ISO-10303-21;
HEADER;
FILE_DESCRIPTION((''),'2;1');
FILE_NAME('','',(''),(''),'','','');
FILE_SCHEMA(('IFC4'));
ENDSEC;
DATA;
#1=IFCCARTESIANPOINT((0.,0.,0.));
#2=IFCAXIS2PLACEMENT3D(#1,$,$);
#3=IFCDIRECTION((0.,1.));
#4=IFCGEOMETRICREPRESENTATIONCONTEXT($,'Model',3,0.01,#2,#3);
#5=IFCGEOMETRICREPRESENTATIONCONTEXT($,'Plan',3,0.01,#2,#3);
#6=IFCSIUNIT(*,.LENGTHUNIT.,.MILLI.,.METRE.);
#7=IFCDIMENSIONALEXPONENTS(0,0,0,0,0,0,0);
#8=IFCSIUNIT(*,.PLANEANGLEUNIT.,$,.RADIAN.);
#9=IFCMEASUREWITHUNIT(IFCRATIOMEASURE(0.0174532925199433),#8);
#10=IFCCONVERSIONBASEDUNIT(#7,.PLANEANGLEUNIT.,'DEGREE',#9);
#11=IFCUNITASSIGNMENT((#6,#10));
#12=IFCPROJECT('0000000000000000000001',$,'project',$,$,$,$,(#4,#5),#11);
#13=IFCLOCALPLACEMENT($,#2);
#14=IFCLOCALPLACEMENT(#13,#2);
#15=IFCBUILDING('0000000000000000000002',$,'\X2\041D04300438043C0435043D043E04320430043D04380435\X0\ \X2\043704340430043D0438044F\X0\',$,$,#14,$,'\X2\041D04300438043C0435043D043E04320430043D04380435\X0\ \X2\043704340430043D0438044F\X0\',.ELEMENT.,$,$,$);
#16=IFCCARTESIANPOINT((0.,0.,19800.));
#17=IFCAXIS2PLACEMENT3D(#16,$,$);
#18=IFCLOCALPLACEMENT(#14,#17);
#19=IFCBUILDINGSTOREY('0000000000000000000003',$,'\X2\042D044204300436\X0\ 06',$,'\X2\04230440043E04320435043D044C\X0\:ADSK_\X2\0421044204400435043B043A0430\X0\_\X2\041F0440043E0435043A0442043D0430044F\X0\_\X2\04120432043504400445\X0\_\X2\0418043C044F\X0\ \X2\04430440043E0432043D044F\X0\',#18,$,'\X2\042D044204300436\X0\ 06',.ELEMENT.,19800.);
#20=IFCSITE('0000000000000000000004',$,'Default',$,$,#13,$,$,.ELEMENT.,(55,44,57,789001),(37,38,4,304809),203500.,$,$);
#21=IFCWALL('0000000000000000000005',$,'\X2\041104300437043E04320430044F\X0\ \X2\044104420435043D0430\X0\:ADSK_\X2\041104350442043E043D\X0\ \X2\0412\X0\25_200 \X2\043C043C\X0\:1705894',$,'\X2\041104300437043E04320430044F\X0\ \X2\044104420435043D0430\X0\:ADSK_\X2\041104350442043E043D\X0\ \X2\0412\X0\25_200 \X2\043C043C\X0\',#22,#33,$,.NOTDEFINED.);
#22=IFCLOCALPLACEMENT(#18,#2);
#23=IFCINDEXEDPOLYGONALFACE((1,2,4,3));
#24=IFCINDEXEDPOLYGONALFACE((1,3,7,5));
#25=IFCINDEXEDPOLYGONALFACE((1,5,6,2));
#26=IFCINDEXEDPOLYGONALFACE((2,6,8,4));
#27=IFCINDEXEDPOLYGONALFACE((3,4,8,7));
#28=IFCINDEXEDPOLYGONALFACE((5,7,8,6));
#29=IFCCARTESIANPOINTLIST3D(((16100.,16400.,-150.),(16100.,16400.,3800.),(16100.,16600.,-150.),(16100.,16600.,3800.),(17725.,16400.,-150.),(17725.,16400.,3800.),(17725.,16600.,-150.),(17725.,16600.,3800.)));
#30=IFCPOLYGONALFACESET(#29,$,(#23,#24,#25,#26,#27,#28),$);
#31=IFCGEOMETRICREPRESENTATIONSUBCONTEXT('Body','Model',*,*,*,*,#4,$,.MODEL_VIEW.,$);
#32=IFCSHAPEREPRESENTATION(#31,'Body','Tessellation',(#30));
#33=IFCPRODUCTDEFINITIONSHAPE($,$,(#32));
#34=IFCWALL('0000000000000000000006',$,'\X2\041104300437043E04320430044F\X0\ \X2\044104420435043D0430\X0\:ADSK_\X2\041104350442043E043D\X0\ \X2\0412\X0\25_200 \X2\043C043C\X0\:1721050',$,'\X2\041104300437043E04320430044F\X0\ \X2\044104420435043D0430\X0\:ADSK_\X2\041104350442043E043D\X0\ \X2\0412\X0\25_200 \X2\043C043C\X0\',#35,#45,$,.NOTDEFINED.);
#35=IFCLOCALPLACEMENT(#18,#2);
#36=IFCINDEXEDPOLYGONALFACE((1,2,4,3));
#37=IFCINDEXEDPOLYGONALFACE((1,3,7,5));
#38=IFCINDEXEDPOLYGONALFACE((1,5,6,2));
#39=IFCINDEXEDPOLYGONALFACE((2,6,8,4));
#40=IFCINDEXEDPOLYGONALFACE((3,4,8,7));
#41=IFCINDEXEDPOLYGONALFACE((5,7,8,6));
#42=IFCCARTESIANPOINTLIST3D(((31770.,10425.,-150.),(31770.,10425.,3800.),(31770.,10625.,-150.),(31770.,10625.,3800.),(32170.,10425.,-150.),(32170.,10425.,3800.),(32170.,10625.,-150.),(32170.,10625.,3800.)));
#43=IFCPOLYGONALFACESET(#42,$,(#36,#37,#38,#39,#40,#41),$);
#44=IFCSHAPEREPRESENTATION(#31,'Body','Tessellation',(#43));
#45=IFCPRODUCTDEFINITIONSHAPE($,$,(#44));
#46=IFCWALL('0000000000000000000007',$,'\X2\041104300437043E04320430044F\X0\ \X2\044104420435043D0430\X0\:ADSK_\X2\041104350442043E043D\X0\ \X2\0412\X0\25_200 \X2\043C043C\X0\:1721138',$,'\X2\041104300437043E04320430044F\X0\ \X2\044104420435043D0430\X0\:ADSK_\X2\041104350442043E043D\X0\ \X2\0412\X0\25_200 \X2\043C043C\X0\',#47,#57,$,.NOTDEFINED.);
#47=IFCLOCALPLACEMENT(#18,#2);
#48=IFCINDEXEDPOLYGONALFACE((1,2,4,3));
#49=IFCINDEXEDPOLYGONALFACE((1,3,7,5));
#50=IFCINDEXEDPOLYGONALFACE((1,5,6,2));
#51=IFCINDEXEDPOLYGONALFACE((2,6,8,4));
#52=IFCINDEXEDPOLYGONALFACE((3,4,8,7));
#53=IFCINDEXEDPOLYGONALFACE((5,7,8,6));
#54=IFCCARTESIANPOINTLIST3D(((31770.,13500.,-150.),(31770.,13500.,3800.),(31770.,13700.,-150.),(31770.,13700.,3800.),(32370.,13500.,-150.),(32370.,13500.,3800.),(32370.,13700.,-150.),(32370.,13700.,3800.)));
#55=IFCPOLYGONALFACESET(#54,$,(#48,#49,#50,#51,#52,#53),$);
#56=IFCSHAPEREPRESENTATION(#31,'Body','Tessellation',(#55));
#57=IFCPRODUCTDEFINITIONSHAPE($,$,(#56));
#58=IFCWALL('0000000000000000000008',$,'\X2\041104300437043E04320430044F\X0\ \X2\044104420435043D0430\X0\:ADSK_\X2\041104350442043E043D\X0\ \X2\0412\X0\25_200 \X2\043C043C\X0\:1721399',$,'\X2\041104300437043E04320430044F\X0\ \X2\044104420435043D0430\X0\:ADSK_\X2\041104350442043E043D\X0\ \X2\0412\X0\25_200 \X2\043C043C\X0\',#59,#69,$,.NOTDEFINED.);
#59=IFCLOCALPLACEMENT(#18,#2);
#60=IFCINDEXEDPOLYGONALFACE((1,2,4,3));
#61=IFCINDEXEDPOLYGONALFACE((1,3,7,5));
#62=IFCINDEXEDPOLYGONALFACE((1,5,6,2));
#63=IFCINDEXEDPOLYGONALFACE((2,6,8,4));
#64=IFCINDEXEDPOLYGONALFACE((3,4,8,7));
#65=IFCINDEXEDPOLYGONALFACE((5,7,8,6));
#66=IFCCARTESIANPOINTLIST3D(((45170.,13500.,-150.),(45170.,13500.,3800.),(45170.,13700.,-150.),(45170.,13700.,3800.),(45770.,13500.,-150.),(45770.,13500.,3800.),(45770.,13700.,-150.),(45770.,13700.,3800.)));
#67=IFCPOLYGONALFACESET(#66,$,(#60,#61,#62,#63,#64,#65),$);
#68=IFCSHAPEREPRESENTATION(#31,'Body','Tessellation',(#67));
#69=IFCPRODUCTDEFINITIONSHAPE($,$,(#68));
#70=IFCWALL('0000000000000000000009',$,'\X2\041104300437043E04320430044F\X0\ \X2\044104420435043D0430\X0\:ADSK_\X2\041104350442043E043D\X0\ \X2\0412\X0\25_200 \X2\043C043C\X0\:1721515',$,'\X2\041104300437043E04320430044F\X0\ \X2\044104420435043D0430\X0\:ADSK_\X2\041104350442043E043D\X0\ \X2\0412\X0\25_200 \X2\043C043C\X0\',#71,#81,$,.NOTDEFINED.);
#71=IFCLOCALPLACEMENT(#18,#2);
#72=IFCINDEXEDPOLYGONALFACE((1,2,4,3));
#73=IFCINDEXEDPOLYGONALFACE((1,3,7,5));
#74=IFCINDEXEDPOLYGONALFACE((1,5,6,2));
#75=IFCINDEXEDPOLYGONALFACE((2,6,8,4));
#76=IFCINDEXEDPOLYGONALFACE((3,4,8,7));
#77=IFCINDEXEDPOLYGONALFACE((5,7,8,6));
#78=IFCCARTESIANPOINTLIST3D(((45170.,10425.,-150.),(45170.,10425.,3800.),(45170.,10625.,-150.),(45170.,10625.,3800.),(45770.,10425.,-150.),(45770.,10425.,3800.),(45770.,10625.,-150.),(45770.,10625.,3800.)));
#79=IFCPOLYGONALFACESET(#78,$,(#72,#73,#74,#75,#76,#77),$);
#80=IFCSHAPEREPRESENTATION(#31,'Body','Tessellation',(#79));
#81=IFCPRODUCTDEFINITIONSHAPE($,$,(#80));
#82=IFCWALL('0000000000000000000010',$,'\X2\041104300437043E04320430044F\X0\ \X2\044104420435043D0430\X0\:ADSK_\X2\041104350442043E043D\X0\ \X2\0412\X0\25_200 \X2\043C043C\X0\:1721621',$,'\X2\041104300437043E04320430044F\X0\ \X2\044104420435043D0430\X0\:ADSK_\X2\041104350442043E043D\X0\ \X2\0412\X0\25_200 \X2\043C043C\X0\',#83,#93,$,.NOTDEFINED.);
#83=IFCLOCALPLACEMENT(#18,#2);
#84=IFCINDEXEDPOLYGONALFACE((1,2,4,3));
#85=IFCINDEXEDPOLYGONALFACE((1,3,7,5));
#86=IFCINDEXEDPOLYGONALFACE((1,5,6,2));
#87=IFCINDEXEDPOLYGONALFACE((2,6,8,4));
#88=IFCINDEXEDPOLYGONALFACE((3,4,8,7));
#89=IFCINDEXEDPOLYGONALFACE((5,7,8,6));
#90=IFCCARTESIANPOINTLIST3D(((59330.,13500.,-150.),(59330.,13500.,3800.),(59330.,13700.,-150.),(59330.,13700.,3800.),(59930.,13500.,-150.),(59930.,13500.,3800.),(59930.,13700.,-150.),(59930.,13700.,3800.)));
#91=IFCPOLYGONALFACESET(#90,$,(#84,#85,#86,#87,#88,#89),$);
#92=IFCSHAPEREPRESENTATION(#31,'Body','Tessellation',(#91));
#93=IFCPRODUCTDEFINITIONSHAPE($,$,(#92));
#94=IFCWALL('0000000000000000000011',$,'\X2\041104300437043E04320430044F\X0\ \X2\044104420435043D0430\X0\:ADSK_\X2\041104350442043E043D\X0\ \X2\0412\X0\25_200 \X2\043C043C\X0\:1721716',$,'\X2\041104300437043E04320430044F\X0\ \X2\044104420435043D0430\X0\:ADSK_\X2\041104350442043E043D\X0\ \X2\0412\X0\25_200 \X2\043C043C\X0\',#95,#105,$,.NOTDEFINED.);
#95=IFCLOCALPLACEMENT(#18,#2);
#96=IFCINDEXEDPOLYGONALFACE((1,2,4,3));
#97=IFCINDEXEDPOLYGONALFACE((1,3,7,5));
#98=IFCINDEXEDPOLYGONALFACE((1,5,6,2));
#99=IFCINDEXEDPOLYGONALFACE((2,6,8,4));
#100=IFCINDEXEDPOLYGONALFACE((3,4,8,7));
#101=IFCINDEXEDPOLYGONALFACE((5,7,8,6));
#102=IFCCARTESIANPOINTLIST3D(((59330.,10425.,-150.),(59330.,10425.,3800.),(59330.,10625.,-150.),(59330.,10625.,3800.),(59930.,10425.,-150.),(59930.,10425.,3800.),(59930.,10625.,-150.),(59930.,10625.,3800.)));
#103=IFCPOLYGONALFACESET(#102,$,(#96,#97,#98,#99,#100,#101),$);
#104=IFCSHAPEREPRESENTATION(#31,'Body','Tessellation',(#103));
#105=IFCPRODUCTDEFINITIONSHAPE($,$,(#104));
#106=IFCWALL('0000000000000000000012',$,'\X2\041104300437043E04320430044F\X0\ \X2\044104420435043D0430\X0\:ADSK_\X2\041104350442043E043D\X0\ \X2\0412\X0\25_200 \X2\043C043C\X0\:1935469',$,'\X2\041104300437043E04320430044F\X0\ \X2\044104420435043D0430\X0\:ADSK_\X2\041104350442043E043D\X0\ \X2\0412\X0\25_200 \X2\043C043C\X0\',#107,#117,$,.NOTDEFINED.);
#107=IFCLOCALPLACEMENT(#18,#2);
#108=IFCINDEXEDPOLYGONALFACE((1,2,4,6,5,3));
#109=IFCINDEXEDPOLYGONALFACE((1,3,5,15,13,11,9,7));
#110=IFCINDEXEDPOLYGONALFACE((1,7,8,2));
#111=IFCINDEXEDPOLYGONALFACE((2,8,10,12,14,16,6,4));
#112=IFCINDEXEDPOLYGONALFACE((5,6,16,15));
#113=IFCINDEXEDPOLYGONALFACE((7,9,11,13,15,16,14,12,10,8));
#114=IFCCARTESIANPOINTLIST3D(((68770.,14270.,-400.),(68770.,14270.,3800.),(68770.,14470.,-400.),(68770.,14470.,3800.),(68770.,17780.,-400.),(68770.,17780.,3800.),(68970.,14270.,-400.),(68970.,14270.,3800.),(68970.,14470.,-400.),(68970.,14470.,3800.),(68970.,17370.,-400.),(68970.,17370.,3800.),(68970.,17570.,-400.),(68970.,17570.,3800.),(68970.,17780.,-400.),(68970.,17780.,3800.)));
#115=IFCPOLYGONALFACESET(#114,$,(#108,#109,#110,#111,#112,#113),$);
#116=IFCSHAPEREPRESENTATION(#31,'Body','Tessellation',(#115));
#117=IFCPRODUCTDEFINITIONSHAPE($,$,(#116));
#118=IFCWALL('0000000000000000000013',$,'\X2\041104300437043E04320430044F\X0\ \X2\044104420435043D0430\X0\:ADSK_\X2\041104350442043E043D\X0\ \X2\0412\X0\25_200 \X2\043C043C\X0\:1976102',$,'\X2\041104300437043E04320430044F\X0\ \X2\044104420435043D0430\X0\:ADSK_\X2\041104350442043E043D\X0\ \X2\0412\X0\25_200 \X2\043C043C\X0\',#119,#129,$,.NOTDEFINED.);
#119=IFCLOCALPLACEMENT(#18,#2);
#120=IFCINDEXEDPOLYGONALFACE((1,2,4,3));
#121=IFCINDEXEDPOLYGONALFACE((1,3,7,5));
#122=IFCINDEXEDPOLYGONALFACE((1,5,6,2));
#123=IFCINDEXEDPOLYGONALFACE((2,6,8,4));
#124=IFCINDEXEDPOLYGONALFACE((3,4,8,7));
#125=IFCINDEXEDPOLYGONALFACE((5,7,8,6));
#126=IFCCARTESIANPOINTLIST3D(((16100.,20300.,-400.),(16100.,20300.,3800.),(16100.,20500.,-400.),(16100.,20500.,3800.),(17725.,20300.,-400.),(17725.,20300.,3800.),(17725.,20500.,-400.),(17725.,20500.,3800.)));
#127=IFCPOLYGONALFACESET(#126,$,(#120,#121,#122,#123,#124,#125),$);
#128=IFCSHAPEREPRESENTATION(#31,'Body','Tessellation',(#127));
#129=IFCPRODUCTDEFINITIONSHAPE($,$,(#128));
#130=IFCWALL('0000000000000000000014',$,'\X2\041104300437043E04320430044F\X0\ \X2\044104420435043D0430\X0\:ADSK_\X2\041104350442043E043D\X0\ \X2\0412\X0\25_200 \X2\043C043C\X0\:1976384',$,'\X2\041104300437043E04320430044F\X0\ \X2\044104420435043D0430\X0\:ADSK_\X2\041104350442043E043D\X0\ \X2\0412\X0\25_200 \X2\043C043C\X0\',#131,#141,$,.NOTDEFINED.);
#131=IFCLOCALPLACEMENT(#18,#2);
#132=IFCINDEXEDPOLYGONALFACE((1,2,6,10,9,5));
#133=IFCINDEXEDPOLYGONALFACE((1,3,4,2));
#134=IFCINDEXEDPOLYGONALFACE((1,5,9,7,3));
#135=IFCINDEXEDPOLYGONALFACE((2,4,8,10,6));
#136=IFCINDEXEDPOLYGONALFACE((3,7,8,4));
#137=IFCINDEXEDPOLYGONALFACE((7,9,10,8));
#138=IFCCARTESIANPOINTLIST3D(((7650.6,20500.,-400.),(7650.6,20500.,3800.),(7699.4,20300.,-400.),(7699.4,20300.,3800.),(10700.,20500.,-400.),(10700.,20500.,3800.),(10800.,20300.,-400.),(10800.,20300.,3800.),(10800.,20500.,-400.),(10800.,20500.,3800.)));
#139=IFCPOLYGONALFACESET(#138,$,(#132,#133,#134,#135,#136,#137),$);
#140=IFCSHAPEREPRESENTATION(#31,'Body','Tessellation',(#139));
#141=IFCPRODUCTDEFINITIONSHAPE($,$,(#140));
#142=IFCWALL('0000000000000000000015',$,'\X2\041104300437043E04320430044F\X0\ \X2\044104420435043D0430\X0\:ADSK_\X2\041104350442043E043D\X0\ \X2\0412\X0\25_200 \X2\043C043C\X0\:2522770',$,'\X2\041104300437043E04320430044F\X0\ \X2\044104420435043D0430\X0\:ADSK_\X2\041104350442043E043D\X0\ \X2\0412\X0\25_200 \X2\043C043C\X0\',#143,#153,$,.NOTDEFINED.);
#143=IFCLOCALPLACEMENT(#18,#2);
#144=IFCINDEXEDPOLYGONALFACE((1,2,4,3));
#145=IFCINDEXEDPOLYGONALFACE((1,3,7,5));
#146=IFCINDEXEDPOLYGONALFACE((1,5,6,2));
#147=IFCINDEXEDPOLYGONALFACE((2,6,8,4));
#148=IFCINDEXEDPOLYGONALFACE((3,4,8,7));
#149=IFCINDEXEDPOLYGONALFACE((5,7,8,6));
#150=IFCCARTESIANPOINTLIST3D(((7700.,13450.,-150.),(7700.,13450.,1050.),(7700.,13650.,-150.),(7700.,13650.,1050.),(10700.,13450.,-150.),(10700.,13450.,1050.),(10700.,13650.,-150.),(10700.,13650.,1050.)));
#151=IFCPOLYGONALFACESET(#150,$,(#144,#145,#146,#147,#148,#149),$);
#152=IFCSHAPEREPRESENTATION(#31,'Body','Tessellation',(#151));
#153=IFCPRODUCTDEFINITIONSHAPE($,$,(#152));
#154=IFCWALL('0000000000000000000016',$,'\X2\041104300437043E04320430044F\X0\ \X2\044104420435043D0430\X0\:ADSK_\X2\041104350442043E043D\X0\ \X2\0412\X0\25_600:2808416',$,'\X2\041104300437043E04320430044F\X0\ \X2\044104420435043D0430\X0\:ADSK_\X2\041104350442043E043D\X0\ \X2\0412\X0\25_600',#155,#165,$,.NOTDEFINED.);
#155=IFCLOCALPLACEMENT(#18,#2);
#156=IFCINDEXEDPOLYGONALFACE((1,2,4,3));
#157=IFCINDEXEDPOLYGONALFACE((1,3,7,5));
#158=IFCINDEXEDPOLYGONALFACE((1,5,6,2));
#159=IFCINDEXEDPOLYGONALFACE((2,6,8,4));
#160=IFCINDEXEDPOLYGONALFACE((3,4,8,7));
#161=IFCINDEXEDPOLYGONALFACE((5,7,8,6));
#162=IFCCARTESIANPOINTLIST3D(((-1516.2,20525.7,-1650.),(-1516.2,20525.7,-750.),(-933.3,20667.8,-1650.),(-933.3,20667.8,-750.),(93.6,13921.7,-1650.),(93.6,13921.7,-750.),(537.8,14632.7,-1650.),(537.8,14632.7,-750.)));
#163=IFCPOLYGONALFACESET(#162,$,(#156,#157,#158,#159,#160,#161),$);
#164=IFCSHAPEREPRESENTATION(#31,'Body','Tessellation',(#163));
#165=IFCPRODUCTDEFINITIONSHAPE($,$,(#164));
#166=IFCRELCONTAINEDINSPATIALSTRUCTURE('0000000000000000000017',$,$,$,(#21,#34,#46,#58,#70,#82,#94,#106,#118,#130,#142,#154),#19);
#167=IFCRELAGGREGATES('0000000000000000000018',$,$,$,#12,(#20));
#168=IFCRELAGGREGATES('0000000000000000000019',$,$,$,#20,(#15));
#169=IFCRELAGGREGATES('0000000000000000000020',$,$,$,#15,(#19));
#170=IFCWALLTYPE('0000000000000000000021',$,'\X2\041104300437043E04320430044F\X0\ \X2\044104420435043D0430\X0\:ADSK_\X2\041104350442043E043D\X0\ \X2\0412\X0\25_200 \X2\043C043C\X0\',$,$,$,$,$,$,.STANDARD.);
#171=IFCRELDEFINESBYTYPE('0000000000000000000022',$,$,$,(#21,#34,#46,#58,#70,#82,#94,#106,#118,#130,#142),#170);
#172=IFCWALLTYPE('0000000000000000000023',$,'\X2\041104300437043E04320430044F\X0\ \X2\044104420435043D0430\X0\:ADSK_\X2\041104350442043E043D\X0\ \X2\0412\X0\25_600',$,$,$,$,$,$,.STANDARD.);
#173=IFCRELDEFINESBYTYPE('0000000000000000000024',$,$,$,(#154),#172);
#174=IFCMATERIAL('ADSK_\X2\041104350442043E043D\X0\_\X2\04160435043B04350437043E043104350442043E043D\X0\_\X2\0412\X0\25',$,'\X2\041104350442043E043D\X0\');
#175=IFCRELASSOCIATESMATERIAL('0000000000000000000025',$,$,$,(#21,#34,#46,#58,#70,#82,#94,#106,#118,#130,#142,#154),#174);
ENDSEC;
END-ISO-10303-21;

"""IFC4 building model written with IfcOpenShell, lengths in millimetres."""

from ifc_helpers import new_model, entity, si_unit, converted_unit, direction, frame, origin, place, context, subcontext, project, spatial, indexed_curve, outline, extrude, material, type_object, element, save


model = new_model("IFC4")

# Units and contexts
model_context = context("Model", 3, precision=0.01, world=origin(), true_north=direction((0.0, 1.0)))
plan_context = context("Plan", 3, precision=0.01, world=origin(), true_north=direction((0.0, 1.0)))
body_context = subcontext(model_context, "Body", "Model", "MODEL_VIEW")
ifc_project = project(units=[si_unit("LENGTHUNIT", "METRE", prefix="MILLI"), converted_unit("PLANEANGLEUNIT", "DEGREE", entity("IfcRatioMeasure", 0.0174532925199433), si_unit("PLANEANGLEUNIT", "RADIAN"), dimensions=[0, 0, 0, 0, 0, 0, 0])], contexts=[model_context, plan_context])

# Site, building, storey
site_placement = place(None, origin())
site = spatial("IfcSite", under=ifc_project, at=site_placement, Name="Default", CompositionType="ELEMENT", RefLatitude=(55, 44, 57, 789001), RefLongitude=(37, 38, 4, 304809), RefElevation=203500.0)
building_placement = place(site_placement, origin())
building = spatial("IfcBuilding", under=site, at=building_placement, Name="Наименование здания", LongName="Наименование здания", CompositionType="ELEMENT")
storey_placement = place(building_placement, frame((0.0, 0.0, 19800.0)))
storey = spatial("IfcBuildingStorey", under=building, at=storey_placement, Name="Этаж 06", ObjectType="Уровень:ADSK_Стрелка_Проектная_Вверх_Имя уровня", LongName="Этаж 06", CompositionType="ELEMENT", Elevation=19800.0)

# Walls
ifc_material = material(Name="ADSK_Бетон_Железобетон_В25", Category="Бетон")
wall_type_1 = type_object("IfcWallType", Name="Базовая стена:ADSK_Бетон В25_200 мм", PredefinedType="STANDARD")
wall_1_placement = place(storey_placement, frame((16100.0, 16500.0, -150.0)))
element("IfcWall", 1, at=wall_1_placement, inside=storey, type_object=wall_type_1, material=ifc_material, Name="Базовая стена:ADSK_Бетон В25_200 мм:1705894", ObjectType="Базовая стена:ADSK_Бетон В25_200 мм", PredefinedType="NOTDEFINED", context=body_context, shape_type="SweptSolid", body=[
    extrude(outline(indexed_curve([(1625.0, 100.0), (0.0, 100.0), (0.0, -100.0), (1625.0, -100.0), (1625.0, 100.0)], self_intersect=False)), origin(), (0.0, 0.0, 1.0), 3950.0),
])
wall_2_placement = place(storey_placement, frame((32170.0, 10525.0, -150.0), z_axis=(0.0, 0.0, 1.0), x_axis=(-1.0, 0.0, 0.0)))
element("IfcWall", 2, at=wall_2_placement, inside=storey, type_object=wall_type_1, material=ifc_material, Name="Базовая стена:ADSK_Бетон В25_200 мм:1721050", ObjectType="Базовая стена:ADSK_Бетон В25_200 мм", PredefinedType="NOTDEFINED", context=body_context, shape_type="SweptSolid", body=[
    extrude(outline(indexed_curve([(400.0, 100.0), (0.0, 100.0), (0.0, -100.0), (400.0, -100.0), (400.0, 100.0)], self_intersect=False)), origin(), (0.0, 0.0, 1.0), 3950.0),
])
wall_3_placement = place(storey_placement, frame((32370.0, 13600.0, -150.0), z_axis=(0.0, 0.0, 1.0), x_axis=(-1.0, 0.0, 0.0)))
element("IfcWall", 3, at=wall_3_placement, inside=storey, type_object=wall_type_1, material=ifc_material, Name="Базовая стена:ADSK_Бетон В25_200 мм:1721138", ObjectType="Базовая стена:ADSK_Бетон В25_200 мм", PredefinedType="NOTDEFINED", context=body_context, shape_type="SweptSolid", body=[
    extrude(outline(indexed_curve([(600.0, 100.0), (0.0, 100.0), (0.0, -100.0), (600.0, -100.0), (600.0, 100.0)], self_intersect=False)), origin(), (0.0, 0.0, 1.0), 3950.0),
])
wall_4_placement = place(storey_placement, frame((45770.0, 13600.0, -150.0), z_axis=(0.0, 0.0, 1.0), x_axis=(-1.0, 0.0, 0.0)))
element("IfcWall", 4, at=wall_4_placement, inside=storey, type_object=wall_type_1, material=ifc_material, Name="Базовая стена:ADSK_Бетон В25_200 мм:1721399", ObjectType="Базовая стена:ADSK_Бетон В25_200 мм", PredefinedType="NOTDEFINED", context=body_context, shape_type="SweptSolid", body=[
    extrude(outline(indexed_curve([(600.0, 100.0), (0.0, 100.0), (0.0, -100.0), (600.0, -100.0), (600.0, 100.0)], self_intersect=False)), origin(), (0.0, 0.0, 1.0), 3950.0),
])
wall_5_placement = place(storey_placement, frame((45770.0, 10525.0, -150.0), z_axis=(0.0, 0.0, 1.0), x_axis=(-1.0, 0.0, 0.0)))
element("IfcWall", 5, at=wall_5_placement, inside=storey, type_object=wall_type_1, material=ifc_material, Name="Базовая стена:ADSK_Бетон В25_200 мм:1721515", ObjectType="Базовая стена:ADSK_Бетон В25_200 мм", PredefinedType="NOTDEFINED", context=body_context, shape_type="SweptSolid", body=[
    extrude(outline(indexed_curve([(600.0, 100.0), (0.0, 100.0), (0.0, -100.0), (600.0, -100.0), (600.0, 100.0)], self_intersect=False)), origin(), (0.0, 0.0, 1.0), 3950.0),
])
wall_6_placement = place(storey_placement, frame((59930.0, 13600.0, -150.0), z_axis=(0.0, 0.0, 1.0), x_axis=(-1.0, 0.0, 0.0)))
element("IfcWall", 6, at=wall_6_placement, inside=storey, type_object=wall_type_1, material=ifc_material, Name="Базовая стена:ADSK_Бетон В25_200 мм:1721621", ObjectType="Базовая стена:ADSK_Бетон В25_200 мм", PredefinedType="NOTDEFINED", context=body_context, shape_type="SweptSolid", body=[
    extrude(outline(indexed_curve([(600.0, 100.0), (0.0, 100.0), (0.0, -100.0), (600.0, -100.0), (600.0, 100.0)], self_intersect=False)), origin(), (0.0, 0.0, 1.0), 3950.0),
])
wall_7_placement = place(storey_placement, frame((59930.0, 10525.0, -150.0), z_axis=(0.0, 0.0, 1.0), x_axis=(-1.0, 0.0, 0.0)))
element("IfcWall", 7, at=wall_7_placement, inside=storey, type_object=wall_type_1, material=ifc_material, Name="Базовая стена:ADSK_Бетон В25_200 мм:1721716", ObjectType="Базовая стена:ADSK_Бетон В25_200 мм", PredefinedType="NOTDEFINED", context=body_context, shape_type="SweptSolid", body=[
    extrude(outline(indexed_curve([(600.0, 100.0), (0.0, 100.0), (0.0, -100.0), (600.0, -100.0), (600.0, 100.0)], self_intersect=False)), origin(), (0.0, 0.0, 1.0), 3950.0),
])
wall_8_placement = place(storey_placement, frame((68870.0, 14270.0, -400.0), z_axis=(0.0, 0.0, 1.0), x_axis=(0.0, 1.0, 0.0)))
element("IfcWall", 8, at=wall_8_placement, inside=storey, type_object=wall_type_1, material=ifc_material, Name="Базовая стена:ADSK_Бетон В25_200 мм:1935469", ObjectType="Базовая стена:ADSK_Бетон В25_200 мм", PredefinedType="NOTDEFINED", context=body_context, shape_type="SweptSolid", body=[
    extrude(outline(indexed_curve([(3510.0, -100.0), (3510.0, 100.0), (200.0, 100.0), (0.0, 100.0), (0.0, -100.0), (200.0, -100.0), (3100.0, -100.0), (3300.0, -100.0), (3510.0, -100.0)], self_intersect=False)), origin(), (0.0, 0.0, 1.0), 4200.0),
])
wall_9_placement = place(storey_placement, frame((17725.0, 20400.0, -400.0), z_axis=(0.0, 0.0, 1.0), x_axis=(-1.0, 0.0, 0.0)))
element("IfcWall", 9, at=wall_9_placement, inside=storey, type_object=wall_type_1, material=ifc_material, Name="Базовая стена:ADSK_Бетон В25_200 мм:1976102", ObjectType="Базовая стена:ADSK_Бетон В25_200 мм", PredefinedType="NOTDEFINED", context=body_context, shape_type="SweptSolid", body=[
    extrude(outline(indexed_curve([(1625.0, 100.0), (0.0, 100.0), (0.0, -100.0), (1625.0, -100.0), (1625.0, 100.0)], self_intersect=False)), origin(), (0.0, 0.0, 1.0), 4200.0),
])
wall_10_placement = place(storey_placement, frame((10800.0, 20400.0, -400.0), z_axis=(0.0, 0.0, 1.0), x_axis=(-1.0, 0.0, 0.0)))
element("IfcWall", 10, at=wall_10_placement, inside=storey, type_object=wall_type_1, material=ifc_material, Name="Базовая стена:ADSK_Бетон В25_200 мм:1976384", ObjectType="Базовая стена:ADSK_Бетон В25_200 мм", PredefinedType="NOTDEFINED", context=body_context, shape_type="SweptSolid", body=[
    extrude(outline(indexed_curve([(3149.4, -100.0), (3100.6, 100.0), (0.0, 100.0), (0.0, -100.0), (100.0, -100.0), (3149.4, -100.0)], self_intersect=False)), origin(), (0.0, 0.0, 1.0), 4200.0),
])
wall_11_placement = place(storey_placement, frame((7700.0, 13550.0, -150.0)))
element("IfcWall", 11, at=wall_11_placement, inside=storey, type_object=wall_type_1, material=ifc_material, Name="Базовая стена:ADSK_Бетон В25_200 мм:2522770", ObjectType="Базовая стена:ADSK_Бетон В25_200 мм", PredefinedType="NOTDEFINED", context=body_context, shape_type="SweptSolid", body=[
    extrude(outline(indexed_curve([(3000.0, 100.0), (0.0, 100.0), (0.0, -100.0), (3000.0, -100.0), (3000.0, 100.0)], self_intersect=False)), origin(), (0.0, 0.0, 1.0), 1200.0),
])
wall_type_2 = type_object("IfcWallType", Name="Базовая стена:ADSK_Бетон В25_600", PredefinedType="STANDARD")
wall_12_placement = place(storey_placement, frame((385.0, 13992.8, -1650.0), z_axis=(0.0, 0.0, 1.0), x_axis=(-0.236826, 0.971552, 0.0)))
element("IfcWall", 12, at=wall_12_placement, inside=storey, type_object=wall_type_2, material=ifc_material, Name="Базовая стена:ADSK_Бетон В25_600:2808416", ObjectType="Базовая стена:ADSK_Бетон В25_600", PredefinedType="NOTDEFINED", context=body_context, shape_type="SweptSolid", body=[
    extrude(outline(indexed_curve([(6797.3, -300.0), (6797.3, 300.0), (0.0, 300.0), (585.5, -300.0), (6797.3, -300.0)], self_intersect=False)), origin(), (0.0, 0.0, 1.0), 900.0),
])

save(model, "model.ifc")
